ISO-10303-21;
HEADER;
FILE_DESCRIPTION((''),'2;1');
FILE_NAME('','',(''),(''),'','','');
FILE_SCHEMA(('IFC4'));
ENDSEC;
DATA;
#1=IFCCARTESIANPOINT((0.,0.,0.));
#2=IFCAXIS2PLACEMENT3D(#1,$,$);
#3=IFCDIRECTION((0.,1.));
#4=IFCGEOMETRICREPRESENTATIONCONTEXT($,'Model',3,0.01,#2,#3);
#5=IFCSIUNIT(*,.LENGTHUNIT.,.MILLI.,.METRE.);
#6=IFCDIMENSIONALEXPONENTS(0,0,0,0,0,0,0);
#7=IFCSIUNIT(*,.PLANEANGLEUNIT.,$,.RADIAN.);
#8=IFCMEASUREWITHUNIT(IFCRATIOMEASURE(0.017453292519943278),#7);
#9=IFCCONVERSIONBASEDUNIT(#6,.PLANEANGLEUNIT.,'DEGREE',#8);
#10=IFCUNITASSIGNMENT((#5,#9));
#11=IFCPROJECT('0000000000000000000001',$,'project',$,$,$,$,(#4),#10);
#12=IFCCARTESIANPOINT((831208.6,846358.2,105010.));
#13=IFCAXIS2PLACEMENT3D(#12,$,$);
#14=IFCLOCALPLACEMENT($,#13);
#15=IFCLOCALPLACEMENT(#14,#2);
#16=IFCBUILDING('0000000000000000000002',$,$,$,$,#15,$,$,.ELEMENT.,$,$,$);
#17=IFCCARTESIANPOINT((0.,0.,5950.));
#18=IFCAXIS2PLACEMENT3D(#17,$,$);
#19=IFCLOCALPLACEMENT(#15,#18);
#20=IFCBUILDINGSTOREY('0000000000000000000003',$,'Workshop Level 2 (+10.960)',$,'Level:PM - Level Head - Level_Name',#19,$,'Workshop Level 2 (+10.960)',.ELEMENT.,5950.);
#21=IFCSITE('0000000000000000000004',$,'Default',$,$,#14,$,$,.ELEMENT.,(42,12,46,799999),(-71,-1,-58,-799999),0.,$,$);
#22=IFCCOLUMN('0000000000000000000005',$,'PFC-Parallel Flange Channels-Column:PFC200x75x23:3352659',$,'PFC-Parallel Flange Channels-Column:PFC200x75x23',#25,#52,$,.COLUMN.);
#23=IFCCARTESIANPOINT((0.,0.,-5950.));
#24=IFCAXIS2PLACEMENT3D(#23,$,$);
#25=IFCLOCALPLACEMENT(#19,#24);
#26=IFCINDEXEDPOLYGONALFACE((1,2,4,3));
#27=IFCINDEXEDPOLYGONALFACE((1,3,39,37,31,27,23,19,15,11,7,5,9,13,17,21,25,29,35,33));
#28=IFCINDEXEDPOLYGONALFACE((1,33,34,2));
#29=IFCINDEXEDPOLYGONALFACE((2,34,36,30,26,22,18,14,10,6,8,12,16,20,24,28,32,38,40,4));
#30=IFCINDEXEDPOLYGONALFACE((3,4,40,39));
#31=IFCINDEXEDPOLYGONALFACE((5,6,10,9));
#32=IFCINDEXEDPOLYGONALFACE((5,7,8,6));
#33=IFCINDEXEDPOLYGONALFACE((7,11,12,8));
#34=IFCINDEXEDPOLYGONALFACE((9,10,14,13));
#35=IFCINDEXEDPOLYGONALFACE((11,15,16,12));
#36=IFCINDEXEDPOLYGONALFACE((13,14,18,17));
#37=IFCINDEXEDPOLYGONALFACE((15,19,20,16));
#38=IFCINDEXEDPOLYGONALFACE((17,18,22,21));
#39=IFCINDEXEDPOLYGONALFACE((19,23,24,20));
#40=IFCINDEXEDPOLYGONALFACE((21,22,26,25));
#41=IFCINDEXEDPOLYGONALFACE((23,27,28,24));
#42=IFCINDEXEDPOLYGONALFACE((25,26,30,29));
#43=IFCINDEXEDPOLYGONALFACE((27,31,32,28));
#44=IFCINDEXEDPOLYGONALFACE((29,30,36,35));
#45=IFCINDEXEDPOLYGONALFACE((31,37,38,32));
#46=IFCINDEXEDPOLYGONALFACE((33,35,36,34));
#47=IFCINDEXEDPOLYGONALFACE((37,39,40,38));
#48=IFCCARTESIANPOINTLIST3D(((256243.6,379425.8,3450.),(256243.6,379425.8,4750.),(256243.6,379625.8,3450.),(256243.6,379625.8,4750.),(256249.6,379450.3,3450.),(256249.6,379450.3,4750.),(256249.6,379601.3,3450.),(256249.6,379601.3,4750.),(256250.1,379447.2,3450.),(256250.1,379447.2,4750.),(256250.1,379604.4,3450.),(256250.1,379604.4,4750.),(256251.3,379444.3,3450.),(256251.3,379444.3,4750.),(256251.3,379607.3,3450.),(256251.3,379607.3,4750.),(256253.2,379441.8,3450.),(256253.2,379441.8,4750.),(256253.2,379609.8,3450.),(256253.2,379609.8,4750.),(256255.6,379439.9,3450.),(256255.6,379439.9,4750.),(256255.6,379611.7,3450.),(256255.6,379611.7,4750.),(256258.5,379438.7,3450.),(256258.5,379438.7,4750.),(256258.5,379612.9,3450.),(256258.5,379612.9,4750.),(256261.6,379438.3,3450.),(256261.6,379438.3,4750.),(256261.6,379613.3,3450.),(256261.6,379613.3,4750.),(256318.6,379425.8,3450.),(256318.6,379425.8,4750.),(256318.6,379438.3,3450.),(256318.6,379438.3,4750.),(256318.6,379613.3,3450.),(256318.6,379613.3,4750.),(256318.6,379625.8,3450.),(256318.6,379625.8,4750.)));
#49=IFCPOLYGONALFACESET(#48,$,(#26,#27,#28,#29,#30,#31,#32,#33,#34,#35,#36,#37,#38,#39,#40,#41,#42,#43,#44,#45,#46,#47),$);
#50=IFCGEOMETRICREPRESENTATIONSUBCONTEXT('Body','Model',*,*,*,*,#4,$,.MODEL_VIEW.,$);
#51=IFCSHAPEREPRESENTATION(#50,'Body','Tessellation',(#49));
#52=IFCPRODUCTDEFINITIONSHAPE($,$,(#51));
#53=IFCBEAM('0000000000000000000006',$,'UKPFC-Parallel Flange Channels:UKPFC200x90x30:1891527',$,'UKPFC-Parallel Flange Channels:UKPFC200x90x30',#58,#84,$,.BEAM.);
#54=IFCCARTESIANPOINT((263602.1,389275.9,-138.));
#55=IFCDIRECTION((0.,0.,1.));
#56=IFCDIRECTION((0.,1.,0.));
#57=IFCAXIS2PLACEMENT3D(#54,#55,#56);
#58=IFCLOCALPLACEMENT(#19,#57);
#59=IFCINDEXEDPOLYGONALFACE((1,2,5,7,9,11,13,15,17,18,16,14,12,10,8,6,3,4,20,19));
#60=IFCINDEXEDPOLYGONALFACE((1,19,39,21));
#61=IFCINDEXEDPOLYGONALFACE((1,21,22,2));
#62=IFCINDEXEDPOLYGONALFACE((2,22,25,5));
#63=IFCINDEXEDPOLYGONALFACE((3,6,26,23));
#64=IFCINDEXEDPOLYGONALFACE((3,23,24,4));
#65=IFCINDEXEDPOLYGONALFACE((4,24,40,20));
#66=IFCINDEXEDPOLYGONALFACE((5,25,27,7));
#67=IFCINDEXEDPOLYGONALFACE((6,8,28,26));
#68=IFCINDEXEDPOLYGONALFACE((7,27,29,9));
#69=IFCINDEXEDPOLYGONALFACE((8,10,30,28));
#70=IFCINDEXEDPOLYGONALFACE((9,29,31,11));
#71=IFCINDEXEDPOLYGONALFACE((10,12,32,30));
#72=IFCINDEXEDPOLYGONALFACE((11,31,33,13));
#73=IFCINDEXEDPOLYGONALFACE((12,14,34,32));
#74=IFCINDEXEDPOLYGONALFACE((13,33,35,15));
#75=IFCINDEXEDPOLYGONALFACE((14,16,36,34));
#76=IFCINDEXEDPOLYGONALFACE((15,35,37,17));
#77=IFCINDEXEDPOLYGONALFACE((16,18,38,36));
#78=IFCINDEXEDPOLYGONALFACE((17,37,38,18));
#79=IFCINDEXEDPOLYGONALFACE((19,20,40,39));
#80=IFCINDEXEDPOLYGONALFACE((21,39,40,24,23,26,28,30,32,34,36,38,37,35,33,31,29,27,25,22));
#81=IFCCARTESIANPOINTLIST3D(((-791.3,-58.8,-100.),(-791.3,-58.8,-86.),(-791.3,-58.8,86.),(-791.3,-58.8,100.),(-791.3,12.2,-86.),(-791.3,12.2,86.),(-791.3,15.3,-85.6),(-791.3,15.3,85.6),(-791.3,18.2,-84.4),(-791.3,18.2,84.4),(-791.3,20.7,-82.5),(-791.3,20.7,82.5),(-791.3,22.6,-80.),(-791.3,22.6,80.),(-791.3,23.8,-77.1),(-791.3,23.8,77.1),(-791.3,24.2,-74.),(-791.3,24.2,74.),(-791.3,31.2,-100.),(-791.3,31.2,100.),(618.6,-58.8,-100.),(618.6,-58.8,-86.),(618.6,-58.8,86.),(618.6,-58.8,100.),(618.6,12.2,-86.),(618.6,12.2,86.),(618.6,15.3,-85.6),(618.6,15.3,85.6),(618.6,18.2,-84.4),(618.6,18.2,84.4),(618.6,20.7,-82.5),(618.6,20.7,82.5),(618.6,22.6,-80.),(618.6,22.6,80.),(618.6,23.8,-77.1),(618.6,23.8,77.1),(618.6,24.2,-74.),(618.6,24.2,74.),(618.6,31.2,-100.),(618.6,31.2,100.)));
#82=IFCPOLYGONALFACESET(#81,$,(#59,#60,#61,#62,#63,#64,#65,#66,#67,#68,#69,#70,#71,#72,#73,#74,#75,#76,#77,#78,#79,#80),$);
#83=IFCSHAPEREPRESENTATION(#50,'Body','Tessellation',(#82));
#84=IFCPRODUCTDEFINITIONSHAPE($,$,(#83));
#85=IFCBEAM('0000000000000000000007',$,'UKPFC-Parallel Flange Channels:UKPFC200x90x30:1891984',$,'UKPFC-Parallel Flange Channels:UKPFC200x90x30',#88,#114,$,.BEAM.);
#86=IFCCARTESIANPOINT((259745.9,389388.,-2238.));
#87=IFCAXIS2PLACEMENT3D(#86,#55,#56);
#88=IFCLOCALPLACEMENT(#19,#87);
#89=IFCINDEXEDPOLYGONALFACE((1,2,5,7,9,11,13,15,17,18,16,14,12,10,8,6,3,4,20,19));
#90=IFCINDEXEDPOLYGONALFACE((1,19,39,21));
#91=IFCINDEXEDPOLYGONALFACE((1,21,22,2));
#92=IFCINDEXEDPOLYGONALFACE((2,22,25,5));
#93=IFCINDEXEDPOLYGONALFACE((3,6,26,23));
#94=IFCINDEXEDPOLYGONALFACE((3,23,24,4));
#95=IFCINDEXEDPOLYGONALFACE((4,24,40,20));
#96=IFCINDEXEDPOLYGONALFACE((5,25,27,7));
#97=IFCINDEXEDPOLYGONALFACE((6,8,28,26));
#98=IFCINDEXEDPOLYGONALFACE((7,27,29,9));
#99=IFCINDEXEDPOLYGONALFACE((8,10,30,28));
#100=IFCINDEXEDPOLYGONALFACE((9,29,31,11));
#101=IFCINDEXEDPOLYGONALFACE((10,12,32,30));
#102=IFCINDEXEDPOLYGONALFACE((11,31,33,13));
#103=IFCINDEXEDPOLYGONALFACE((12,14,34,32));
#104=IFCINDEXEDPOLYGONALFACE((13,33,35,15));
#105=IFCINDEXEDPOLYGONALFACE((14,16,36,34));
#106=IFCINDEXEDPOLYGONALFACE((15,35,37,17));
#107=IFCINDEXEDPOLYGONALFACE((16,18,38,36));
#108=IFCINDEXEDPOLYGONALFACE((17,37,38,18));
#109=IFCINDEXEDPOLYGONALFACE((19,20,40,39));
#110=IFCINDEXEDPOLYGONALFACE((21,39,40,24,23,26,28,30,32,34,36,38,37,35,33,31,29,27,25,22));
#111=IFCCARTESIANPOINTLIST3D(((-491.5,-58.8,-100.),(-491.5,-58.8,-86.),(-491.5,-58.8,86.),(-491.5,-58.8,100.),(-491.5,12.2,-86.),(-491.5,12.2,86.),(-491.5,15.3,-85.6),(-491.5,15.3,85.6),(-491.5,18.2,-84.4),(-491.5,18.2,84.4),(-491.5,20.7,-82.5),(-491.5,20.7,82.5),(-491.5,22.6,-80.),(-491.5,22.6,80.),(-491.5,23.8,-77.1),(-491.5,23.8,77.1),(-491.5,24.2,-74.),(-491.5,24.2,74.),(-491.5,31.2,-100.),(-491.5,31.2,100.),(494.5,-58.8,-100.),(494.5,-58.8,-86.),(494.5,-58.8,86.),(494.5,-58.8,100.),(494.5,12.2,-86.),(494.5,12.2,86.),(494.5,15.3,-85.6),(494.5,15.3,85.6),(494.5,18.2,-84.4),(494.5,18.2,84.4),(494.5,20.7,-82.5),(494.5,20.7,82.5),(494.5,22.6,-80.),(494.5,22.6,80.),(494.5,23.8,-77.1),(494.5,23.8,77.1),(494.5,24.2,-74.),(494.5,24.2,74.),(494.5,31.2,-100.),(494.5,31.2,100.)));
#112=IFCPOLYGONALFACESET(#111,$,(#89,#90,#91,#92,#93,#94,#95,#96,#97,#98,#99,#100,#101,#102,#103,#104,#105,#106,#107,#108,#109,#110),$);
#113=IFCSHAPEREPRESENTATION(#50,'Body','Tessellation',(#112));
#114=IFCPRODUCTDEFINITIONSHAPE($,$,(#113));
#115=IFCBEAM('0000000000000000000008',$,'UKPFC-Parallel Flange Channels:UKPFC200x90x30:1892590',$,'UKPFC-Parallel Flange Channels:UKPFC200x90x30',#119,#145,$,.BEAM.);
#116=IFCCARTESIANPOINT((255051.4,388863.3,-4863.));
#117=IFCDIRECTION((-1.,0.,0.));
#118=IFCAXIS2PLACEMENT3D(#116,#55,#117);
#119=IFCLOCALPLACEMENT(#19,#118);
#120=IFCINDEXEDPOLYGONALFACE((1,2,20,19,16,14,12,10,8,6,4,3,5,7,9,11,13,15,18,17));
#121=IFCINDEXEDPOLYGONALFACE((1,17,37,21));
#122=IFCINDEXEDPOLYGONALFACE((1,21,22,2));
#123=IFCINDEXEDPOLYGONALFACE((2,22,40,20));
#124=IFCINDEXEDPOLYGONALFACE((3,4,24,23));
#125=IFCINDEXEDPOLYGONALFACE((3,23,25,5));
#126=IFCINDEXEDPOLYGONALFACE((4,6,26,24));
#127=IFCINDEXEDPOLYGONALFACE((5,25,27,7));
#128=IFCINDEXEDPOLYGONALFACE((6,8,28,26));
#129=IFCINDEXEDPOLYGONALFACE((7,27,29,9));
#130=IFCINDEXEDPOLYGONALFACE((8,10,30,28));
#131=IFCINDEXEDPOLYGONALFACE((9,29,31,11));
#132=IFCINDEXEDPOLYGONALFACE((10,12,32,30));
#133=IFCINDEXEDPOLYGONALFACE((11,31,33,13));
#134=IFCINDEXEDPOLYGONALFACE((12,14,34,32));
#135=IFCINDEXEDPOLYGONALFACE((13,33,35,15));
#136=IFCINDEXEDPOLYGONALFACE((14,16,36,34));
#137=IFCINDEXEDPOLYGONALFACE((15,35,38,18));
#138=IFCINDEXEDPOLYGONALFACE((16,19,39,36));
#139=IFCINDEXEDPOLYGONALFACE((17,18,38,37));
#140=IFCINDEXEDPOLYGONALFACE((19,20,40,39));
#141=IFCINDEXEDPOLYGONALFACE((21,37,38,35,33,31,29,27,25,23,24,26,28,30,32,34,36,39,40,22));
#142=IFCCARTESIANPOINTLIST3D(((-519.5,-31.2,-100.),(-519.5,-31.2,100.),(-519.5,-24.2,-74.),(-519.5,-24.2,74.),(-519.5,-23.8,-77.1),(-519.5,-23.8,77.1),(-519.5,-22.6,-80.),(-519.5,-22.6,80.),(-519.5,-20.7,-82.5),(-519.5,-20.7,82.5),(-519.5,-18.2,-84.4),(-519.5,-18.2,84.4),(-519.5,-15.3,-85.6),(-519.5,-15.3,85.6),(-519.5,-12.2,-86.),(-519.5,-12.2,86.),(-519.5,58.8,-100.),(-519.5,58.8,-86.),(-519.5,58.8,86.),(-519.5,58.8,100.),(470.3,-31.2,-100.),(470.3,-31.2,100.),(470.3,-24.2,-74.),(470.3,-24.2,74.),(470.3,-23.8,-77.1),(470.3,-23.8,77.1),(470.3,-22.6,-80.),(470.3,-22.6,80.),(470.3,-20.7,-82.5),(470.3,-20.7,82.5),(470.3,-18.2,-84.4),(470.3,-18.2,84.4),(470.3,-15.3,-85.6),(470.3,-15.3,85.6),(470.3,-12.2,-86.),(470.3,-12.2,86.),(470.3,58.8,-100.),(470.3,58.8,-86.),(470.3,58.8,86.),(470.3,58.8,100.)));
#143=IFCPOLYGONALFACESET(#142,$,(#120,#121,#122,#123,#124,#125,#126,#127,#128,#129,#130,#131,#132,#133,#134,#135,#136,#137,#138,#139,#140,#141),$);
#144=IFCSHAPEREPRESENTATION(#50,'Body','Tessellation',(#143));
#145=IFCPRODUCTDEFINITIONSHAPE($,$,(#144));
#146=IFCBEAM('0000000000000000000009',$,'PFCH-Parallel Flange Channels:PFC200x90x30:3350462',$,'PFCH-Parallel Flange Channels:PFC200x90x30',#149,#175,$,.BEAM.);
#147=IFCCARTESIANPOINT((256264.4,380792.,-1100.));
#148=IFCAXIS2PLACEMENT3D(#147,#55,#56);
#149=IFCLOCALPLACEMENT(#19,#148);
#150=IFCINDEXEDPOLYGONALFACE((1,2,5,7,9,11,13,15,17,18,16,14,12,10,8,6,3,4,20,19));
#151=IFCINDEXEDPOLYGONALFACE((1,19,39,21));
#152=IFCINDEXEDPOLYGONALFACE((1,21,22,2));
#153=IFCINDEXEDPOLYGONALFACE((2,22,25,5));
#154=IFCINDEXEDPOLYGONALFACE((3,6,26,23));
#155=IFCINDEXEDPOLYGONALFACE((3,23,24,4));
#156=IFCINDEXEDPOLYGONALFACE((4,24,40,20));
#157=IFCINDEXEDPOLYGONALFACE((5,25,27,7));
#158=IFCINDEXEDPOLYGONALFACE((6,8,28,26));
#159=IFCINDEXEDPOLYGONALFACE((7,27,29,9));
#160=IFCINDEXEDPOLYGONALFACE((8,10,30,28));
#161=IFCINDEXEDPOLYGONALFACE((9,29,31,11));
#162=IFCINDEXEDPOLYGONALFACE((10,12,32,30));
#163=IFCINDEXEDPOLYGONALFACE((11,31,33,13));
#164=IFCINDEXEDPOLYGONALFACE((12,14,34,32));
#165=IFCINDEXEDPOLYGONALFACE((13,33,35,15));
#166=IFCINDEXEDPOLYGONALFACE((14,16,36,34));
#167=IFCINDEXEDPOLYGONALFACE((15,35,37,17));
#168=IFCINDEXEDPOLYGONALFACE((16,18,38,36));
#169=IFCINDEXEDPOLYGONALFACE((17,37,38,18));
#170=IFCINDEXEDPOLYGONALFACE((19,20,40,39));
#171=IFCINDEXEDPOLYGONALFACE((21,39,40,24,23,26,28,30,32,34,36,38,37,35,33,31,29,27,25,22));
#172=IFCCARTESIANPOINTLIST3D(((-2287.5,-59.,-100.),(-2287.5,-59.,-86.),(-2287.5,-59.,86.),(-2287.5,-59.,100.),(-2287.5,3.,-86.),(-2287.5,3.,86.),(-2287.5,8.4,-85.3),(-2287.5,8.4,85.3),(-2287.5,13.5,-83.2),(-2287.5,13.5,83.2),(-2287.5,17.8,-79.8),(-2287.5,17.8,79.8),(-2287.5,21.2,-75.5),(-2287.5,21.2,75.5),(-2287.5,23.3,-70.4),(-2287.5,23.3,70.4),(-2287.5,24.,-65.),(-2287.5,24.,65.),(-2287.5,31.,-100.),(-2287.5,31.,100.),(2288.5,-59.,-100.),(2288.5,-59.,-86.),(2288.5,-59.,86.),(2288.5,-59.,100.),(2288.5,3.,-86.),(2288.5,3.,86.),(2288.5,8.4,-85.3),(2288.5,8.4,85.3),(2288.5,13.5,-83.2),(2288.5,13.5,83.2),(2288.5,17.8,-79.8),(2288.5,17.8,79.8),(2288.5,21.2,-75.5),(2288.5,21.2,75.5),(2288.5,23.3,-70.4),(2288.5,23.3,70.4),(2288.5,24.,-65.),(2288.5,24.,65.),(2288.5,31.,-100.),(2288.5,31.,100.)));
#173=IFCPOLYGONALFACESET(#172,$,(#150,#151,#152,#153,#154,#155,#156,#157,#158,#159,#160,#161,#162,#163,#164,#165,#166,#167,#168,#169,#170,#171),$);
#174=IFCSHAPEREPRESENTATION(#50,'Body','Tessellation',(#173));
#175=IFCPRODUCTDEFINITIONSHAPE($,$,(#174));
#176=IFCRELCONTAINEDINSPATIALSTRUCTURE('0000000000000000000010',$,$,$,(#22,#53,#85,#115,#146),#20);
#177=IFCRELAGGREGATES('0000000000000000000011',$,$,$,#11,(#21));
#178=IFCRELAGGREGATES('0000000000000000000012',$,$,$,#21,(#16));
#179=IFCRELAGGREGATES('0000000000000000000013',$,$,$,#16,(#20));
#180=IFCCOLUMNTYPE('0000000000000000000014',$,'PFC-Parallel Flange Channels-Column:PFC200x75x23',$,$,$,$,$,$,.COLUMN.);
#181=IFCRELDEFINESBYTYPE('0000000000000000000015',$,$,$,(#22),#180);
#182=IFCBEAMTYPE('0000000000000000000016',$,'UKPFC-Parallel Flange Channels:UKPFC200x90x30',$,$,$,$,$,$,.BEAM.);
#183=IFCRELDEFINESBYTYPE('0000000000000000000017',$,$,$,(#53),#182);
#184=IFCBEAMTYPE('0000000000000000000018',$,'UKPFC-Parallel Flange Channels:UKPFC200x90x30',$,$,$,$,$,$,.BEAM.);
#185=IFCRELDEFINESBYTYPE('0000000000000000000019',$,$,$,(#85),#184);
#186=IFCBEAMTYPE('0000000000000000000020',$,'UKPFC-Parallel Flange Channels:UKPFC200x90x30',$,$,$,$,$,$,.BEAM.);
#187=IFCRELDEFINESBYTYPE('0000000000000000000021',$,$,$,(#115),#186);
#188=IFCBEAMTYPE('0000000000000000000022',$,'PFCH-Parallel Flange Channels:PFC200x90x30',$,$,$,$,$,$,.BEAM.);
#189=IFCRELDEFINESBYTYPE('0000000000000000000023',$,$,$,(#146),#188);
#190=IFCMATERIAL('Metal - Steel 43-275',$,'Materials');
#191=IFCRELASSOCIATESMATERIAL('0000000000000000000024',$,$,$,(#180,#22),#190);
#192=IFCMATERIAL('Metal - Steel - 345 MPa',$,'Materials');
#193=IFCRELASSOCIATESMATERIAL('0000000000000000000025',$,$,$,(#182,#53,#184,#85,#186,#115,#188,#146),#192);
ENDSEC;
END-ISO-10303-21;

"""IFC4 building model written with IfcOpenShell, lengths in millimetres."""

from ifc_helpers import new_model, entity, si_unit, converted_unit, direction, frame, origin, place, context, subcontext, project, spatial, line, arc, indexed_curve, outline, extrude, source, transform, mapped, material, type_object, type_shapes, element, save


model = new_model("IFC4")

# Units and contexts
model_context = context("Model", 3, precision=0.01, world=origin(), true_north=direction((0.0, 1.0)))
body_context = subcontext(model_context, "Body", "Model", "MODEL_VIEW")
ifc_project = project(units=[si_unit("LENGTHUNIT", "METRE", prefix="MILLI"), converted_unit("PLANEANGLEUNIT", "DEGREE", entity("IfcRatioMeasure", 0.017453292519943278), si_unit("PLANEANGLEUNIT", "RADIAN"), dimensions=[0, 0, 0, 0, 0, 0, 0])], contexts=[model_context])

# Site, building, storey
site_placement = place(None, frame((831208.6, 846358.2, 105010.0)))
site = spatial("IfcSite", under=ifc_project, at=site_placement, Name="Default", CompositionType="ELEMENT", RefLatitude=(42, 12, 46, 799999), RefLongitude=(-71, -1, -58, -799999), RefElevation=0.0)
building_placement = place(site_placement, origin())
building = spatial("IfcBuilding", under=site, at=building_placement, CompositionType="ELEMENT")
storey_placement = place(building_placement, frame((0.0, 0.0, 5950.0)))
storey = spatial("IfcBuildingStorey", under=building, at=storey_placement, Name="Workshop Level 2 (+10.960)", ObjectType="Level:PM - Level Head - Level_Name", LongName="Workshop Level 2 (+10.960)", CompositionType="ELEMENT", Elevation=5950.0)

# Column
ifc_material_1 = material(Name="Metal - Steel 43-275", Category="Materials")
column_type_1 = type_object("IfcColumnType", Name="PFC-Parallel Flange Channels-Column:PFC200x75x23", PredefinedType="COLUMN", material=ifc_material_1)
shared_shape_1 = source(origin(), body_context, "Body", "SweptSolid", [
    extrude(outline(indexed_curve([(-100.0, -34.8), (100.0, -34.8), (100.0, 40.2), (87.5, 40.2), (87.5, -16.8), (84.0, -25.3), (75.5, -28.8), (-75.5, -28.8), (-84.0, -25.3), (-87.5, -16.8), (-87.5, 40.2), (-100.0, 40.2)], segments=[line(1, 2, 3, 4, 5), arc(5, 6, 7), line(7, 8), arc(8, 9, 10), line(10, 11, 12, 1)], self_intersect=False)), frame((256278.4, 379525.8, 3450.0), z_axis=(0.0, 0.0, 1.0), x_axis=(0.0, -1.0, 0.0)), (0.0, 0.0, 1.0), 1300.0),
])
type_shapes(column_type_1, [shared_shape_1])
column_1_placement = place(storey_placement, frame((0.0, 0.0, -5950.0)))
element("IfcColumn", 1, at=column_1_placement, inside=storey, type_object=column_type_1, material=ifc_material_1, Name="PFC-Parallel Flange Channels-Column:PFC200x75x23:3352659", ObjectType="PFC-Parallel Flange Channels-Column:PFC200x75x23", PredefinedType="COLUMN", context=body_context, shape_type="MappedRepresentation", body=[
    mapped(shared_shape_1, transform((0.0, 0.0, 0.0), scale=1.0)),
])

# Beams
ifc_material_2 = material(Name="Metal - Steel - 345 MPa", Category="Materials")
beam_type_1 = type_object("IfcBeamType", Name="UKPFC-Parallel Flange Channels:UKPFC200x90x30", PredefinedType="BEAM", material=ifc_material_2)
shared_shape_2 = source(origin(), body_context, "Body", "SweptSolid", [
    extrude(outline(indexed_curve([(-100.0, -48.8), (-86.0, -48.8), (-86.0, 22.2), (-82.5, 30.7), (-74.0, 34.2), (74.0, 34.2), (82.5, 30.7), (86.0, 22.2), (86.0, -48.8), (100.0, -48.8), (100.0, 41.2), (-100.0, 41.2)], segments=[line(1, 2, 3), arc(3, 4, 5), line(5, 6), arc(6, 7, 8), line(8, 9, 10, 11, 12, 1)], self_intersect=False)), frame((-791.3, -10.0, 0.0), z_axis=(1.0, 0.0, 0.0), x_axis=(0.0, 0.0, -1.0)), (0.0, 0.0, 1.0), 1409.9),
])
type_shapes(beam_type_1, [shared_shape_2])
beam_1_placement = place(storey_placement, frame((263602.1, 389275.9, -138.0), z_axis=(0.0, 0.0, 1.0), x_axis=(0.0, 1.0, 0.0)))
element("IfcBeam", 2, at=beam_1_placement, inside=storey, type_object=beam_type_1, material=ifc_material_2, Name="UKPFC-Parallel Flange Channels:UKPFC200x90x30:1891527", ObjectType="UKPFC-Parallel Flange Channels:UKPFC200x90x30", PredefinedType="BEAM", context=body_context, shape_type="MappedRepresentation", body=[
    mapped(shared_shape_2, transform((0.0, 0.0, 0.0), scale=1.0)),
])
beam_type_2 = type_object("IfcBeamType", Name="UKPFC-Parallel Flange Channels:UKPFC200x90x30", PredefinedType="BEAM", material=ifc_material_2)
shared_shape_3 = source(origin(), body_context, "Body", "SweptSolid", [
    extrude(outline(indexed_curve([(-100.0, -48.8), (-86.0, -48.8), (-86.0, 22.2), (-82.5, 30.7), (-74.0, 34.2), (74.0, 34.2), (82.5, 30.7), (86.0, 22.2), (86.0, -48.8), (100.0, -48.8), (100.0, 41.2), (-100.0, 41.2)], segments=[line(1, 2, 3), arc(3, 4, 5), line(5, 6), arc(6, 7, 8), line(8, 9, 10, 11, 12, 1)], self_intersect=False)), frame((-491.5, -10.0, 0.0), z_axis=(1.0, 0.0, 0.0), x_axis=(0.0, 0.0, -1.0)), (0.0, 0.0, 1.0), 986.0),
])
type_shapes(beam_type_2, [shared_shape_3])
beam_2_placement = place(storey_placement, frame((259745.9, 389388.0, -2238.0), z_axis=(0.0, 0.0, 1.0), x_axis=(0.0, 1.0, 0.0)))
element("IfcBeam", 3, at=beam_2_placement, inside=storey, type_object=beam_type_2, material=ifc_material_2, Name="UKPFC-Parallel Flange Channels:UKPFC200x90x30:1891984", ObjectType="UKPFC-Parallel Flange Channels:UKPFC200x90x30", PredefinedType="BEAM", context=body_context, shape_type="MappedRepresentation", body=[
    mapped(shared_shape_3, transform((0.0, 0.0, 0.0), scale=1.0)),
])
beam_type_3 = type_object("IfcBeamType", Name="UKPFC-Parallel Flange Channels:UKPFC200x90x30", PredefinedType="BEAM", material=ifc_material_2)
shared_shape_4 = source(origin(), body_context, "Body", "SweptSolid", [
    extrude(outline(indexed_curve([(-100.0, -41.2), (100.0, -41.2), (100.0, 48.8), (86.0, 48.8), (86.0, -22.2), (82.5, -30.7), (74.0, -34.2), (-74.0, -34.2), (-82.5, -30.7), (-86.0, -22.2), (-86.0, 48.8), (-100.0, 48.8)], segments=[line(1, 2, 3, 4, 5), arc(5, 6, 7), line(7, 8), arc(8, 9, 10), line(10, 11, 12, 1)], self_intersect=False)), frame((-519.5, 10.0, 0.0), z_axis=(1.0, 0.0, 0.0), x_axis=(0.0, 0.0, -1.0)), (0.0, 0.0, 1.0), 989.8),
])
type_shapes(beam_type_3, [shared_shape_4])
beam_3_placement = place(storey_placement, frame((255051.4, 388863.3, -4863.0), z_axis=(0.0, 0.0, 1.0), x_axis=(-1.0, 0.0, 0.0)))
element("IfcBeam", 4, at=beam_3_placement, inside=storey, type_object=beam_type_3, material=ifc_material_2, Name="UKPFC-Parallel Flange Channels:UKPFC200x90x30:1892590", ObjectType="UKPFC-Parallel Flange Channels:UKPFC200x90x30", PredefinedType="BEAM", context=body_context, shape_type="MappedRepresentation", body=[
    mapped(shared_shape_4, transform((0.0, 0.0, 0.0), scale=1.0)),
])
beam_type_4 = type_object("IfcBeamType", Name="PFCH-Parallel Flange Channels:PFC200x90x30", PredefinedType="BEAM", material=ifc_material_2)
shared_shape_5 = source(origin(), body_context, "Body", "SweptSolid", [
    extrude(outline(indexed_curve([(-100.0, -47.0), (-86.0, -47.0), (-86.0, 15.0), (-79.8, 29.8), (-65.0, 36.0), (65.0, 36.0), (79.8, 29.8), (86.0, 15.0), (86.0, -47.0), (100.0, -47.0), (100.0, 43.0), (-100.0, 43.0)], segments=[line(1, 2, 3), arc(3, 4, 5), line(5, 6), arc(6, 7, 8), line(8, 9, 10, 11, 12, 1)], self_intersect=False)), frame((-2287.5, -12.0, 0.0), z_axis=(1.0, 0.0, 0.0), x_axis=(0.0, 0.0, -1.0)), (0.0, 0.0, 1.0), 4576.0),
])
type_shapes(beam_type_4, [shared_shape_5])
beam_4_placement = place(storey_placement, frame((256264.4, 380792.0, -1100.0), z_axis=(0.0, 0.0, 1.0), x_axis=(0.0, 1.0, 0.0)))
element("IfcBeam", 5, at=beam_4_placement, inside=storey, type_object=beam_type_4, material=ifc_material_2, Name="PFCH-Parallel Flange Channels:PFC200x90x30:3350462", ObjectType="PFCH-Parallel Flange Channels:PFC200x90x30", PredefinedType="BEAM", context=body_context, shape_type="MappedRepresentation", body=[
    mapped(shared_shape_5, transform((0.0, 0.0, 0.0), scale=1.0)),
])

save(model, "model.ifc")
